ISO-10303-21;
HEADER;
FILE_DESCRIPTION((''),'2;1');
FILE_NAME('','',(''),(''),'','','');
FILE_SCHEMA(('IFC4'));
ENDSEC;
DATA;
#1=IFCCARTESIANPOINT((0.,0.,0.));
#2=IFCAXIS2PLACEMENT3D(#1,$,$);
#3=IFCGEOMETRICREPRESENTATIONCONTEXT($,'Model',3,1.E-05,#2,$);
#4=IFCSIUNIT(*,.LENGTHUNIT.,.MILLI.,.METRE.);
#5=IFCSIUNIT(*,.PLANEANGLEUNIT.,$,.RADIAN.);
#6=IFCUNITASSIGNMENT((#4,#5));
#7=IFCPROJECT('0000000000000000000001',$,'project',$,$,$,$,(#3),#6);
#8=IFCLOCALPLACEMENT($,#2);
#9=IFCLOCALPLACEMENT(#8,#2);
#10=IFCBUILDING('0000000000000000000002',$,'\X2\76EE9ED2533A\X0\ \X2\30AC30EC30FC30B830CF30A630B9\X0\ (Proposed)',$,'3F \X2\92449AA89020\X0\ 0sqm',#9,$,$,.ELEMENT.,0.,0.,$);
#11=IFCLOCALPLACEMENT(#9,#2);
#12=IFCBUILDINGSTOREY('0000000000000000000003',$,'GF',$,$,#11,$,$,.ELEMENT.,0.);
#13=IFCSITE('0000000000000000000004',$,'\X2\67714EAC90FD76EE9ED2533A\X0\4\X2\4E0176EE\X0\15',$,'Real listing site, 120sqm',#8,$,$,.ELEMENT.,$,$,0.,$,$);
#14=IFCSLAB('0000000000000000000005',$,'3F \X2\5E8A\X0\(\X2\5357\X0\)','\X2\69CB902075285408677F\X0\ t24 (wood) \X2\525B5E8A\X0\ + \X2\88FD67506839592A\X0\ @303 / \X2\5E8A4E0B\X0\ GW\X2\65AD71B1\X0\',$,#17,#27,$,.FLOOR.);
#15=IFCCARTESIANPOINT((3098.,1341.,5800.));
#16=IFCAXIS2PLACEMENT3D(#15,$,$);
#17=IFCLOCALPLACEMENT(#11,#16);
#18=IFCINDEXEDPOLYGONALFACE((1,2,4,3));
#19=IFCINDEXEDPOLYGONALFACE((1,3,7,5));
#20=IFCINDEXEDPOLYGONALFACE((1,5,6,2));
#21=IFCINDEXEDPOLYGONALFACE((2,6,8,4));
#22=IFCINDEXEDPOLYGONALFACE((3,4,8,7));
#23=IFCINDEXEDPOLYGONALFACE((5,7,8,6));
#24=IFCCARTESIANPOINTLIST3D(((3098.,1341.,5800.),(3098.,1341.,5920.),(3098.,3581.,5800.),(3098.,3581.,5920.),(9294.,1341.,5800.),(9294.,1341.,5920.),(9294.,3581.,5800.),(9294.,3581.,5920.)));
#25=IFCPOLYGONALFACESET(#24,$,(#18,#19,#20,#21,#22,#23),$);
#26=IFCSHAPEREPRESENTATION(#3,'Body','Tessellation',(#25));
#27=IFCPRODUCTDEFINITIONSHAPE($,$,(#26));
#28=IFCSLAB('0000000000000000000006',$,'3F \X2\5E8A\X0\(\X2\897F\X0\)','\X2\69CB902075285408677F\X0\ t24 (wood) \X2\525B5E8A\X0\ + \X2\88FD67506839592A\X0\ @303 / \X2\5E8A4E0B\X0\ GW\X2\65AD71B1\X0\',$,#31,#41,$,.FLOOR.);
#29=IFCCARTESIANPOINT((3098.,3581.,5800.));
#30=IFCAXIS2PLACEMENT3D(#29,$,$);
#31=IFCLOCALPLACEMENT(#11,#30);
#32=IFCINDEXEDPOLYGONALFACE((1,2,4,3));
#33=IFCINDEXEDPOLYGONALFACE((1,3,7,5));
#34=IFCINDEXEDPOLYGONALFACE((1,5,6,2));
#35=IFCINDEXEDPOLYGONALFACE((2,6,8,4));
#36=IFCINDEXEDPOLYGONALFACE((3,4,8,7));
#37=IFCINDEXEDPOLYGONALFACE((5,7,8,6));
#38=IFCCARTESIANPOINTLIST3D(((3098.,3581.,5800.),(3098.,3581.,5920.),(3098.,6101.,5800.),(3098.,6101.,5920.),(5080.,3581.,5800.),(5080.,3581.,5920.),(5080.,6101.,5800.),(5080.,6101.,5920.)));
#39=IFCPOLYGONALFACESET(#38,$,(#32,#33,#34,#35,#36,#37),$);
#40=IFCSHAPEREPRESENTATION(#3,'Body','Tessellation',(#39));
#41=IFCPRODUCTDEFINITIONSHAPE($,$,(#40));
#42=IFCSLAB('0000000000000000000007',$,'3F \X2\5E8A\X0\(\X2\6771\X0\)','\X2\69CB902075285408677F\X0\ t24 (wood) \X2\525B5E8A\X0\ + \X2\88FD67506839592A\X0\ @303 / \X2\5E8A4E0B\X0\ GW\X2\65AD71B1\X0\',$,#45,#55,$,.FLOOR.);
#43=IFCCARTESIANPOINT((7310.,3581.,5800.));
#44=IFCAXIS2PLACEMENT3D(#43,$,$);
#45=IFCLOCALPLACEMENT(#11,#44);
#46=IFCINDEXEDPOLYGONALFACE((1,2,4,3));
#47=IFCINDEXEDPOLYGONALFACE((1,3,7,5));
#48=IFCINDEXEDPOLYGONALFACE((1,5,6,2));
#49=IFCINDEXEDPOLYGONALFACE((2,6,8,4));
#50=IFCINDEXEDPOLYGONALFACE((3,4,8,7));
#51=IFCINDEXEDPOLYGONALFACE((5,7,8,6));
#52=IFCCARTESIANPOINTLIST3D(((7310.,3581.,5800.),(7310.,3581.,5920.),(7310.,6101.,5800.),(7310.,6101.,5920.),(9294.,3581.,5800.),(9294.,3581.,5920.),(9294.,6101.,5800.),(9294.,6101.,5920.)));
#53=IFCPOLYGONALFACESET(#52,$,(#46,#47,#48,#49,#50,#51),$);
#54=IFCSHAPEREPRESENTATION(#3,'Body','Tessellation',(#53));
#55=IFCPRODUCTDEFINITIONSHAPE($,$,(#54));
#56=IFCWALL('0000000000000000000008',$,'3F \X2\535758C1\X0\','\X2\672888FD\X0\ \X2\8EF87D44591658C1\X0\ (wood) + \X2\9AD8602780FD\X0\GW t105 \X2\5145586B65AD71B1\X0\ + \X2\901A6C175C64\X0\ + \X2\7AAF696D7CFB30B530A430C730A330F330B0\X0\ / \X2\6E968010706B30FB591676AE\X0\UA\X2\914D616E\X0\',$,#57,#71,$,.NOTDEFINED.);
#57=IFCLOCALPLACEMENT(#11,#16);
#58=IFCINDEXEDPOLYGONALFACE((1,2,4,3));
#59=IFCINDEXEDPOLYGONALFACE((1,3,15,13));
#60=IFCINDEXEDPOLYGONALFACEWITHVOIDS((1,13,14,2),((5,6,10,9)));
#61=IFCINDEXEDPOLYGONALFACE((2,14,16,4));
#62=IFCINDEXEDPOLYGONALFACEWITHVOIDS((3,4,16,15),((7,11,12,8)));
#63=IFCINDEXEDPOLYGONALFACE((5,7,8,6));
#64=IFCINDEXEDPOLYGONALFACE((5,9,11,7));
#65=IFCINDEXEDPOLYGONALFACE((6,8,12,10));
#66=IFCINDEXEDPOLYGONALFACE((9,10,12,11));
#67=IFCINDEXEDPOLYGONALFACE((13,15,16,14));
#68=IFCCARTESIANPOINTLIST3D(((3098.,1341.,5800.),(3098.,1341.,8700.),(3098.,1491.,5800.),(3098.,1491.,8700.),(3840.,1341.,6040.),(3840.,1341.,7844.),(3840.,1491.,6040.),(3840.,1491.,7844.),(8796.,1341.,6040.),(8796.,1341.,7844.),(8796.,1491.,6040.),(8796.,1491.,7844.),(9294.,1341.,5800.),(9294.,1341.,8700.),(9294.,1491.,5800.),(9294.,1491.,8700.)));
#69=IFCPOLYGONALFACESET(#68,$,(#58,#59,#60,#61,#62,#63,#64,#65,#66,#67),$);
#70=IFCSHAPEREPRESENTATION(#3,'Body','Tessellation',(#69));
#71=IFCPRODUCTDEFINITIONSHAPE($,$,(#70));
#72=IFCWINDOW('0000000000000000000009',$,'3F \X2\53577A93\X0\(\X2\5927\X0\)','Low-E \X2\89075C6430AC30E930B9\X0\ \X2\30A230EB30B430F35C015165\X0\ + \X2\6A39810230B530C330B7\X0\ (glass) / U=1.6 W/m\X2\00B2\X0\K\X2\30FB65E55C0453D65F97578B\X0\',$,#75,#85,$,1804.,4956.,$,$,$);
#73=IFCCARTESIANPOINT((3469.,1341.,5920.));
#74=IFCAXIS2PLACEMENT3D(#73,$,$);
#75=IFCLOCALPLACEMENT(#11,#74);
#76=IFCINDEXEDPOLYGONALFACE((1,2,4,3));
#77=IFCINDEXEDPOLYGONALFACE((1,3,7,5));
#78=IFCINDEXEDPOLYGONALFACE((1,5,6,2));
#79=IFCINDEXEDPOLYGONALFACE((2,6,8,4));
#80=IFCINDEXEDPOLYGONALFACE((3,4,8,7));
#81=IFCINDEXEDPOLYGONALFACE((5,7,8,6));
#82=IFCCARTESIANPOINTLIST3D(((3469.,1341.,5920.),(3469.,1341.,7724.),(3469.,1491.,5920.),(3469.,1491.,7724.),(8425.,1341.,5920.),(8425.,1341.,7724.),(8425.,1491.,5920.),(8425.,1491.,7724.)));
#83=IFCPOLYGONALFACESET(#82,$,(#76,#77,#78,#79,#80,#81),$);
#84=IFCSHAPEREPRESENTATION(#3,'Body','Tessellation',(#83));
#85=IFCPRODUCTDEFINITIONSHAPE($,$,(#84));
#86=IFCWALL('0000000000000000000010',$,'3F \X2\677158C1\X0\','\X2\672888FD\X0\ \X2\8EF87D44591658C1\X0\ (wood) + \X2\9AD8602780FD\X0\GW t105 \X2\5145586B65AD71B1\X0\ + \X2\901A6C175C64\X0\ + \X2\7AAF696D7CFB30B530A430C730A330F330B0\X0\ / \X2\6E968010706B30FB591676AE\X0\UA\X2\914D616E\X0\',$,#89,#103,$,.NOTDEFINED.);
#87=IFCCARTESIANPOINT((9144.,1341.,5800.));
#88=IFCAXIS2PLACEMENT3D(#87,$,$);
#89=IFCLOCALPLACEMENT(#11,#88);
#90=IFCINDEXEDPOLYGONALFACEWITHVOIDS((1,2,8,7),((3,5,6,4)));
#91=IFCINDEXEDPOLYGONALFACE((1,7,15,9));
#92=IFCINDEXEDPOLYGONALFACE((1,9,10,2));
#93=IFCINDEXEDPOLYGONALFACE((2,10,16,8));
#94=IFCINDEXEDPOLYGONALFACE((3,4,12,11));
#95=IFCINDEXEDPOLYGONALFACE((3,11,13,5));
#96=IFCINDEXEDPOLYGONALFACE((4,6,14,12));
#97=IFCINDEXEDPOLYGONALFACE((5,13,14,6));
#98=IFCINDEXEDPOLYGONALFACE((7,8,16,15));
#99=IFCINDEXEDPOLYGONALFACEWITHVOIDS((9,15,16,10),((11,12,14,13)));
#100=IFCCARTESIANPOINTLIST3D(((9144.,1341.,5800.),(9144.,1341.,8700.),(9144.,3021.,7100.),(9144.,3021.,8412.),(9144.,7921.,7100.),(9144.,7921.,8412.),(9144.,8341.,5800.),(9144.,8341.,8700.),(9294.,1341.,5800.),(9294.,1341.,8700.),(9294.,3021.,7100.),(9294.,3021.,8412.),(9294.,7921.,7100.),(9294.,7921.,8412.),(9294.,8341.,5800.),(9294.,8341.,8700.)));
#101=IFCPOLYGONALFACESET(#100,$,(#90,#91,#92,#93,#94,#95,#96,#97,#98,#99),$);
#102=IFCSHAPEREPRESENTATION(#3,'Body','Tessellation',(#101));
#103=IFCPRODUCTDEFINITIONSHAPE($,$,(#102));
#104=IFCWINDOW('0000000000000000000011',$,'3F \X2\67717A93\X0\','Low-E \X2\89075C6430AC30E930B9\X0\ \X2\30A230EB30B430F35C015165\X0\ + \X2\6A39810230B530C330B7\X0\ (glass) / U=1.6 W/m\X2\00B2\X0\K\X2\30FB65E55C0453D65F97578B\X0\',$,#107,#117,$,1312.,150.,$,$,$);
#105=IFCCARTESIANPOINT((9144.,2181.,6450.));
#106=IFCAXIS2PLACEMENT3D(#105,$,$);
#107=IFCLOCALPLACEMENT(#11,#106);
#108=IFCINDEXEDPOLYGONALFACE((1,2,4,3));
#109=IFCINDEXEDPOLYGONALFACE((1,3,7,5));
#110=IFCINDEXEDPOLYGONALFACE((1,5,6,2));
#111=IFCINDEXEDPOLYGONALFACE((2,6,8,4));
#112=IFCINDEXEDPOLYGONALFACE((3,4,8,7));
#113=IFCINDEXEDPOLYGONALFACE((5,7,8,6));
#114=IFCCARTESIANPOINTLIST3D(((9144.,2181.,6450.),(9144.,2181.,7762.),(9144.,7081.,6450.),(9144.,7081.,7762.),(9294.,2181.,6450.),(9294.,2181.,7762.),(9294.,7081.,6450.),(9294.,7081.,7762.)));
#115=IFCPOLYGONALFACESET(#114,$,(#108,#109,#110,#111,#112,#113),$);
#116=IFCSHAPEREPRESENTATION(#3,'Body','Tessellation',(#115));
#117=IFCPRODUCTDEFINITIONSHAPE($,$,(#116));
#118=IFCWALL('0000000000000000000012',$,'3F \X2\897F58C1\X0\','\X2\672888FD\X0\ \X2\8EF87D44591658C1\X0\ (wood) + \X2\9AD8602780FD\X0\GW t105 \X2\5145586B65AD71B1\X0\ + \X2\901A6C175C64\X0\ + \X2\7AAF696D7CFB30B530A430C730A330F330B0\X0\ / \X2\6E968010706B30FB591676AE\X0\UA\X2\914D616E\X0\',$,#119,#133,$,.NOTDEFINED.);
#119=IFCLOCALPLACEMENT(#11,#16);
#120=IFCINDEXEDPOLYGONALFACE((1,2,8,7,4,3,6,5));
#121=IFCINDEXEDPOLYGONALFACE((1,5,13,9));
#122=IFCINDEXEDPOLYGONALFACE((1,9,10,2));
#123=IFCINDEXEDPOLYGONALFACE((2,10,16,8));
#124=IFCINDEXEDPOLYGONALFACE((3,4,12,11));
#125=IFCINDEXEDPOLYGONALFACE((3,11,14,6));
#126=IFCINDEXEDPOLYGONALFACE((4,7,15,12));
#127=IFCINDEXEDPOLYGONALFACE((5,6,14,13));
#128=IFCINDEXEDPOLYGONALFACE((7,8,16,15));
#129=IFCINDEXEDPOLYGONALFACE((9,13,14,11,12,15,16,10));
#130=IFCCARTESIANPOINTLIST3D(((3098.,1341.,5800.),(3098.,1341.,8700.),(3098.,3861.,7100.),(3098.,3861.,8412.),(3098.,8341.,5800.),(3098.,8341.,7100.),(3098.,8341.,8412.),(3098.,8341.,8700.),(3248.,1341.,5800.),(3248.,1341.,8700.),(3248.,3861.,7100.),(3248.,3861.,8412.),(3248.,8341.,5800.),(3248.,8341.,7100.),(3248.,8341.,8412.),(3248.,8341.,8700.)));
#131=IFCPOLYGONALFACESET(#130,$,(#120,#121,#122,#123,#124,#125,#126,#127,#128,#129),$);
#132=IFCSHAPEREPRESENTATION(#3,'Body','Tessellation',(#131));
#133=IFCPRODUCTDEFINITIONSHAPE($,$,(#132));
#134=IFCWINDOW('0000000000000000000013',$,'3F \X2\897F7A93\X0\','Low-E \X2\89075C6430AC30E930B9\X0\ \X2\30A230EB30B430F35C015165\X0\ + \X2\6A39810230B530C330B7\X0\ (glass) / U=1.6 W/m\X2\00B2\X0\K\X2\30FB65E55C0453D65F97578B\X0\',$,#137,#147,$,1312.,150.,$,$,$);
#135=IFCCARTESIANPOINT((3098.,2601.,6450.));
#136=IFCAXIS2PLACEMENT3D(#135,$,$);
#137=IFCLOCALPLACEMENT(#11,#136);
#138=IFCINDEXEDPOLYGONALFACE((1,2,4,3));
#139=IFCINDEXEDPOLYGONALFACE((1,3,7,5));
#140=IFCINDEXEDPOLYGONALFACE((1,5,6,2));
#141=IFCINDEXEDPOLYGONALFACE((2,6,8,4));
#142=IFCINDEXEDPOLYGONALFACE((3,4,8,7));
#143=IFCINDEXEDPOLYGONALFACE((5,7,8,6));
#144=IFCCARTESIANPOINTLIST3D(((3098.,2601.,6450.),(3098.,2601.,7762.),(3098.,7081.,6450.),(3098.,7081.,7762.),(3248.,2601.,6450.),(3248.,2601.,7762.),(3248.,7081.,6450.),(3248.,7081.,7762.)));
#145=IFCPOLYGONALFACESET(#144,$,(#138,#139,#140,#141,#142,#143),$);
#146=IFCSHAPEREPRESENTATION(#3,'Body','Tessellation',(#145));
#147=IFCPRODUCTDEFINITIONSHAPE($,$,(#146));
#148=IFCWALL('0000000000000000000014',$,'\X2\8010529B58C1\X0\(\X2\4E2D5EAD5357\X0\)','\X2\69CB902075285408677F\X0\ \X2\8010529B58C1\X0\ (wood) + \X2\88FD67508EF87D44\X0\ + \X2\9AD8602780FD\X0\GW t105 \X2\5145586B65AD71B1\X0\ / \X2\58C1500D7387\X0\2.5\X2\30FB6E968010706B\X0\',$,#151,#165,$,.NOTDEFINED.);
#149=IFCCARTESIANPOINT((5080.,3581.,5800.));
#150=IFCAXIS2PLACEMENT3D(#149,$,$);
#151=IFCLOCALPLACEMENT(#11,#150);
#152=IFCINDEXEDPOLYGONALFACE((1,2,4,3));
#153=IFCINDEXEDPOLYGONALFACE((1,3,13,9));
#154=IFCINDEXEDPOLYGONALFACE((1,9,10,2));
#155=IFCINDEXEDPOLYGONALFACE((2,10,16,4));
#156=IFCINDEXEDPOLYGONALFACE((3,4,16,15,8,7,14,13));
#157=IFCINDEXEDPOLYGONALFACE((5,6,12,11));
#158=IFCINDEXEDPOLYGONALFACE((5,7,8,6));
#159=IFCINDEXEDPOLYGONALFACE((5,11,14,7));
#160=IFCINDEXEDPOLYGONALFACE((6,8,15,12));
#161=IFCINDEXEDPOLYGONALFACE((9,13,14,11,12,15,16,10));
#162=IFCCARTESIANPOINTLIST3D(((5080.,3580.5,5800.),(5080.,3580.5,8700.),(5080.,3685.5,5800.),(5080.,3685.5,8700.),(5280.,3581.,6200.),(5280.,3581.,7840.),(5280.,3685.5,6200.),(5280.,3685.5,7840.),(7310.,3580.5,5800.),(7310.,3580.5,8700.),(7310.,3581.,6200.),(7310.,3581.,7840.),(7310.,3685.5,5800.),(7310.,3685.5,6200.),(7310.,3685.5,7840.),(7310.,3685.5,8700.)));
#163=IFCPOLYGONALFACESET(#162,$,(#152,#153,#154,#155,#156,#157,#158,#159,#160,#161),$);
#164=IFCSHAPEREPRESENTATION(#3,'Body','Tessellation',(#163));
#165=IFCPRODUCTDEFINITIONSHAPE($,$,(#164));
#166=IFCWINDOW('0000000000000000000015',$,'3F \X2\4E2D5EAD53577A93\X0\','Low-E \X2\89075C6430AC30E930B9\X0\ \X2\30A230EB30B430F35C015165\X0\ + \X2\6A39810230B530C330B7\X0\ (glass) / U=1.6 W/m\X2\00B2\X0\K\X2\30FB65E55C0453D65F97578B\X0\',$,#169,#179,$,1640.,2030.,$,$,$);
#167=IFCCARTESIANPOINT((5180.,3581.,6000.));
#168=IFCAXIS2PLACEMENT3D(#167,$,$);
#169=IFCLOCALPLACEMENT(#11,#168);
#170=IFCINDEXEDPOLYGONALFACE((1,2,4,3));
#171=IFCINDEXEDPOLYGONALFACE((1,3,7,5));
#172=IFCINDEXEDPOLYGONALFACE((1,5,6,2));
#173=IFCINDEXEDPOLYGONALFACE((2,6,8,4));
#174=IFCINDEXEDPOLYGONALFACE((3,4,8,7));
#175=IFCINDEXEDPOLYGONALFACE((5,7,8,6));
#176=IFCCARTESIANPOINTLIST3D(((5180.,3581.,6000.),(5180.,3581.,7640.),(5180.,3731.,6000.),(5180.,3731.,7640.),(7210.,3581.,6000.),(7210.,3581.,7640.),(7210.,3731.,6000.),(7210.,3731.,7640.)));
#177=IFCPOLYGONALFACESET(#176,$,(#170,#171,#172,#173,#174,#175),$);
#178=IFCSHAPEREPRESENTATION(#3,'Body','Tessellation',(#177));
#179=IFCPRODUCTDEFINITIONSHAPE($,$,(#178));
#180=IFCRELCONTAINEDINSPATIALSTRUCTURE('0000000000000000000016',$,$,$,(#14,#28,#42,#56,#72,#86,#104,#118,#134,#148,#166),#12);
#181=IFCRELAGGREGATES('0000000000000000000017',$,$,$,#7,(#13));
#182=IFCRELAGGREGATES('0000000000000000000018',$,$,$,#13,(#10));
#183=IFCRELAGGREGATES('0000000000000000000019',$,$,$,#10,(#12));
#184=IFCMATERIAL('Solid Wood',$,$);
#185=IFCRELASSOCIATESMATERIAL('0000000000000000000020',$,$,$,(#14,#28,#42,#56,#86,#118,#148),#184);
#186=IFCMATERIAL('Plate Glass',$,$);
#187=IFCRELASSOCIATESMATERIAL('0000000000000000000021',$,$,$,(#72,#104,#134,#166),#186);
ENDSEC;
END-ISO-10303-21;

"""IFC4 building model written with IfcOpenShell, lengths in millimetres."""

from ifc_helpers import new_model, si_unit, frame, frame_2d, origin, place, context, project, spatial, rectangle, extrude, material, element, fill, save


model = new_model("IFC4")

# Units and contexts
model_context = context("Model", 3, precision=1e-05, world=origin())
ifc_project = project(units=[si_unit("LENGTHUNIT", "METRE", prefix="MILLI"), si_unit("PLANEANGLEUNIT", "RADIAN")], contexts=[model_context])

# Site, building, storey
site_placement = place(None, origin())
site = spatial("IfcSite", under=ifc_project, at=site_placement, Name="東京都目黒区4丁目15", ObjectType="Real listing site, 120sqm", CompositionType="ELEMENT", RefElevation=0.0)
building_placement = place(site_placement, origin())
building = spatial("IfcBuilding", under=site, at=building_placement, Name="目黒区 ガレージハウス (Proposed)", ObjectType="3F 鉄骨造 0sqm", CompositionType="ELEMENT", ElevationOfRefHeight=0.0, ElevationOfTerrain=0.0)
storey_placement = place(building_placement, origin())
storey = spatial("IfcBuildingStorey", under=building, at=storey_placement, Name="GF", CompositionType="ELEMENT", Elevation=0.0)

# Slabs
ifc_material_1 = material(Name="Solid Wood")
slab_1_placement = place(storey_placement, frame((3098.0, 1341.0, 5800.0)))
element("IfcSlab", 1, at=slab_1_placement, inside=storey, material=ifc_material_1, Name="3F 床(南)", Description="構造用合板 t24 (wood) 剛床 + 製材根太 @303 / 床下 GW断熱", PredefinedType="FLOOR", context=model_context, shape_type="SweptSolid", body=[
    extrude(rectangle(XDim=6196.0, YDim=2240.0, at=frame_2d((3098.0, 1120.0))), frame((3098.0, 1341.0, 5800.0)), (0.0, 0.0, 1.0), 120.0),
])
slab_2_placement = place(storey_placement, frame((3098.0, 3581.0, 5800.0)))
element("IfcSlab", 2, at=slab_2_placement, inside=storey, material=ifc_material_1, Name="3F 床(西)", Description="構造用合板 t24 (wood) 剛床 + 製材根太 @303 / 床下 GW断熱", PredefinedType="FLOOR", context=model_context, shape_type="SweptSolid", body=[
    extrude(rectangle(XDim=1982.0, YDim=2520.0, at=frame_2d((991.0, 1260.0))), frame((3098.0, 3581.0, 5800.0)), (0.0, 0.0, 1.0), 120.0),
])
slab_3_placement = place(storey_placement, frame((7310.0, 3581.0, 5800.0)))
element("IfcSlab", 3, at=slab_3_placement, inside=storey, material=ifc_material_1, Name="3F 床(東)", Description="構造用合板 t24 (wood) 剛床 + 製材根太 @303 / 床下 GW断熱", PredefinedType="FLOOR", context=model_context, shape_type="SweptSolid", body=[
    extrude(rectangle(XDim=1984.0, YDim=2520.0, at=frame_2d((992.0, 1260.0))), frame((7310.0, 3581.0, 5800.0)), (0.0, 0.0, 1.0), 120.0),
])

# Walls, openings, windows
wall_1_placement = place(storey_placement, frame((3098.0, 1341.0, 5800.0)))
wall_1 = element("IfcWall", 4, at=wall_1_placement, inside=storey, material=ifc_material_1, Name="3F 南壁", Description="木製 軸組外壁 (wood) + 高性能GW t105 充填断熱 + 通気層 + 窯業系サイディング / 準耐火・外皮UA配慮", PredefinedType="NOTDEFINED", context=model_context, shape_type="SweptSolid", body=[
    extrude(rectangle(XDim=6196.0, YDim=150.0, at=frame_2d((3098.0, 75.0))), frame((3098.0, 1341.0, 5800.0)), (0.0, 0.0, 1.0), 2900.0),
])
opening_1_placement = place(storey_placement, frame((3469.0, 1341.0, 5920.0)))
opening_1 = element("IfcOpeningElement", 5, at=opening_1_placement, cuts=wall_1, PredefinedType="NOTDEFINED", context=model_context, shape_type="SweptSolid", body=[
    extrude(rectangle(XDim=4956.0, YDim=150.0, at=frame_2d((2478.0, 75.0))), frame((3469.0, 1341.0, 5920.0)), (0.0, 0.0, 1.0), 1804.0),
])
ifc_material_2 = material(Name="Plate Glass")
window_1_placement = place(storey_placement, frame((3469.0, 1341.0, 5920.0)))
window_1 = element("IfcWindow", 6, at=window_1_placement, inside=storey, material=ifc_material_2, Name="3F 南窓(大)", Description="Low-E 複層ガラス アルゴン封入 + 樹脂サッシ (glass) / U=1.6 W/m²K・日射取得型", OverallHeight=1804.0, OverallWidth=4956.0, context=model_context, shape_type="SweptSolid", body=[
    extrude(rectangle(XDim=4956.0, YDim=150.0, at=frame_2d((2478.0, 75.0))), frame((3469.0, 1341.0, 5920.0)), (0.0, 0.0, 1.0), 1804.0),
])
fill(opening_1, window_1)
wall_2_placement = place(storey_placement, frame((9144.0, 1341.0, 5800.0)))
wall_2 = element("IfcWall", 7, at=wall_2_placement, inside=storey, material=ifc_material_1, Name="3F 東壁", Description="木製 軸組外壁 (wood) + 高性能GW t105 充填断熱 + 通気層 + 窯業系サイディング / 準耐火・外皮UA配慮", PredefinedType="NOTDEFINED", context=model_context, shape_type="SweptSolid", body=[
    extrude(rectangle(XDim=150.0, YDim=7000.0, at=frame_2d((75.0, 3500.0))), frame((9144.0, 1341.0, 5800.0)), (0.0, 0.0, 1.0), 2900.0),
])
opening_2_placement = place(storey_placement, frame((9144.0, 2181.0, 6450.0)))
opening_2 = element("IfcOpeningElement", 8, at=opening_2_placement, cuts=wall_2, PredefinedType="NOTDEFINED", context=model_context, shape_type="SweptSolid", body=[
    extrude(rectangle(XDim=150.0, YDim=4900.0, at=frame_2d((75.0, 2450.0))), frame((9144.0, 2181.0, 6450.0)), (0.0, 0.0, 1.0), 1312.0),
])
window_2_placement = place(storey_placement, frame((9144.0, 2181.0, 6450.0)))
window_2 = element("IfcWindow", 9, at=window_2_placement, inside=storey, material=ifc_material_2, Name="3F 東窓", Description="Low-E 複層ガラス アルゴン封入 + 樹脂サッシ (glass) / U=1.6 W/m²K・日射取得型", OverallHeight=1312.0, OverallWidth=150.0, context=model_context, shape_type="SweptSolid", body=[
    extrude(rectangle(XDim=150.0, YDim=4900.0, at=frame_2d((75.0, 2450.0))), frame((9144.0, 2181.0, 6450.0)), (0.0, 0.0, 1.0), 1312.0),
])
fill(opening_2, window_2)
wall_3_placement = place(storey_placement, frame((3098.0, 1341.0, 5800.0)))
wall_3 = element("IfcWall", 10, at=wall_3_placement, inside=storey, material=ifc_material_1, Name="3F 西壁", Description="木製 軸組外壁 (wood) + 高性能GW t105 充填断熱 + 通気層 + 窯業系サイディング / 準耐火・外皮UA配慮", PredefinedType="NOTDEFINED", context=model_context, shape_type="SweptSolid", body=[
    extrude(rectangle(XDim=150.0, YDim=7000.0, at=frame_2d((75.0, 3500.0))), frame((3098.0, 1341.0, 5800.0)), (0.0, 0.0, 1.0), 2900.0),
])
opening_3_placement = place(storey_placement, frame((3098.0, 2601.0, 6450.0)))
opening_3 = element("IfcOpeningElement", 11, at=opening_3_placement, cuts=wall_3, PredefinedType="NOTDEFINED", context=model_context, shape_type="SweptSolid", body=[
    extrude(rectangle(XDim=150.0, YDim=4480.0, at=frame_2d((75.0, 2240.0))), frame((3098.0, 2601.0, 6450.0)), (0.0, 0.0, 1.0), 1312.0),
])
window_3_placement = place(storey_placement, frame((3098.0, 2601.0, 6450.0)))
window_3 = element("IfcWindow", 12, at=window_3_placement, inside=storey, material=ifc_material_2, Name="3F 西窓", Description="Low-E 複層ガラス アルゴン封入 + 樹脂サッシ (glass) / U=1.6 W/m²K・日射取得型", OverallHeight=1312.0, OverallWidth=150.0, context=model_context, shape_type="SweptSolid", body=[
    extrude(rectangle(XDim=150.0, YDim=4480.0, at=frame_2d((75.0, 2240.0))), frame((3098.0, 2601.0, 6450.0)), (0.0, 0.0, 1.0), 1312.0),
])
fill(opening_3, window_3)
wall_4_placement = place(storey_placement, frame((5080.0, 3581.0, 5800.0)))
wall_4 = element("IfcWall", 13, at=wall_4_placement, inside=storey, material=ifc_material_1, Name="耐力壁(中庭南)", Description="構造用合板 耐力壁 (wood) + 製材軸組 + 高性能GW t105 充填断熱 / 壁倍率2.5・準耐火", PredefinedType="NOTDEFINED", context=model_context, shape_type="SweptSolid", body=[
    extrude(rectangle(XDim=2230.0, YDim=105.0, at=frame_2d((1115.0, 52.0))), frame((5080.0, 3581.0, 5800.0)), (0.0, 0.0, 1.0), 2900.0),
])
opening_4_placement = place(storey_placement, frame((5180.0, 3581.0, 6000.0)))
opening_4 = element("IfcOpeningElement", 14, at=opening_4_placement, cuts=wall_4, PredefinedType="NOTDEFINED", context=model_context, shape_type="SweptSolid", body=[
    extrude(rectangle(XDim=2030.0, YDim=150.0, at=frame_2d((1015.0, 75.0))), frame((5180.0, 3581.0, 6000.0)), (0.0, 0.0, 1.0), 1640.0),
])
window_4_placement = place(storey_placement, frame((5180.0, 3581.0, 6000.0)))
window_4 = element("IfcWindow", 15, at=window_4_placement, inside=storey, material=ifc_material_2, Name="3F 中庭南窓", Description="Low-E 複層ガラス アルゴン封入 + 樹脂サッシ (glass) / U=1.6 W/m²K・日射取得型", OverallHeight=1640.0, OverallWidth=2030.0, context=model_context, shape_type="SweptSolid", body=[
    extrude(rectangle(XDim=2030.0, YDim=150.0, at=frame_2d((1015.0, 75.0))), frame((5180.0, 3581.0, 6000.0)), (0.0, 0.0, 1.0), 1640.0),
])
fill(opening_4, window_4)

save(model, "model.ifc")
